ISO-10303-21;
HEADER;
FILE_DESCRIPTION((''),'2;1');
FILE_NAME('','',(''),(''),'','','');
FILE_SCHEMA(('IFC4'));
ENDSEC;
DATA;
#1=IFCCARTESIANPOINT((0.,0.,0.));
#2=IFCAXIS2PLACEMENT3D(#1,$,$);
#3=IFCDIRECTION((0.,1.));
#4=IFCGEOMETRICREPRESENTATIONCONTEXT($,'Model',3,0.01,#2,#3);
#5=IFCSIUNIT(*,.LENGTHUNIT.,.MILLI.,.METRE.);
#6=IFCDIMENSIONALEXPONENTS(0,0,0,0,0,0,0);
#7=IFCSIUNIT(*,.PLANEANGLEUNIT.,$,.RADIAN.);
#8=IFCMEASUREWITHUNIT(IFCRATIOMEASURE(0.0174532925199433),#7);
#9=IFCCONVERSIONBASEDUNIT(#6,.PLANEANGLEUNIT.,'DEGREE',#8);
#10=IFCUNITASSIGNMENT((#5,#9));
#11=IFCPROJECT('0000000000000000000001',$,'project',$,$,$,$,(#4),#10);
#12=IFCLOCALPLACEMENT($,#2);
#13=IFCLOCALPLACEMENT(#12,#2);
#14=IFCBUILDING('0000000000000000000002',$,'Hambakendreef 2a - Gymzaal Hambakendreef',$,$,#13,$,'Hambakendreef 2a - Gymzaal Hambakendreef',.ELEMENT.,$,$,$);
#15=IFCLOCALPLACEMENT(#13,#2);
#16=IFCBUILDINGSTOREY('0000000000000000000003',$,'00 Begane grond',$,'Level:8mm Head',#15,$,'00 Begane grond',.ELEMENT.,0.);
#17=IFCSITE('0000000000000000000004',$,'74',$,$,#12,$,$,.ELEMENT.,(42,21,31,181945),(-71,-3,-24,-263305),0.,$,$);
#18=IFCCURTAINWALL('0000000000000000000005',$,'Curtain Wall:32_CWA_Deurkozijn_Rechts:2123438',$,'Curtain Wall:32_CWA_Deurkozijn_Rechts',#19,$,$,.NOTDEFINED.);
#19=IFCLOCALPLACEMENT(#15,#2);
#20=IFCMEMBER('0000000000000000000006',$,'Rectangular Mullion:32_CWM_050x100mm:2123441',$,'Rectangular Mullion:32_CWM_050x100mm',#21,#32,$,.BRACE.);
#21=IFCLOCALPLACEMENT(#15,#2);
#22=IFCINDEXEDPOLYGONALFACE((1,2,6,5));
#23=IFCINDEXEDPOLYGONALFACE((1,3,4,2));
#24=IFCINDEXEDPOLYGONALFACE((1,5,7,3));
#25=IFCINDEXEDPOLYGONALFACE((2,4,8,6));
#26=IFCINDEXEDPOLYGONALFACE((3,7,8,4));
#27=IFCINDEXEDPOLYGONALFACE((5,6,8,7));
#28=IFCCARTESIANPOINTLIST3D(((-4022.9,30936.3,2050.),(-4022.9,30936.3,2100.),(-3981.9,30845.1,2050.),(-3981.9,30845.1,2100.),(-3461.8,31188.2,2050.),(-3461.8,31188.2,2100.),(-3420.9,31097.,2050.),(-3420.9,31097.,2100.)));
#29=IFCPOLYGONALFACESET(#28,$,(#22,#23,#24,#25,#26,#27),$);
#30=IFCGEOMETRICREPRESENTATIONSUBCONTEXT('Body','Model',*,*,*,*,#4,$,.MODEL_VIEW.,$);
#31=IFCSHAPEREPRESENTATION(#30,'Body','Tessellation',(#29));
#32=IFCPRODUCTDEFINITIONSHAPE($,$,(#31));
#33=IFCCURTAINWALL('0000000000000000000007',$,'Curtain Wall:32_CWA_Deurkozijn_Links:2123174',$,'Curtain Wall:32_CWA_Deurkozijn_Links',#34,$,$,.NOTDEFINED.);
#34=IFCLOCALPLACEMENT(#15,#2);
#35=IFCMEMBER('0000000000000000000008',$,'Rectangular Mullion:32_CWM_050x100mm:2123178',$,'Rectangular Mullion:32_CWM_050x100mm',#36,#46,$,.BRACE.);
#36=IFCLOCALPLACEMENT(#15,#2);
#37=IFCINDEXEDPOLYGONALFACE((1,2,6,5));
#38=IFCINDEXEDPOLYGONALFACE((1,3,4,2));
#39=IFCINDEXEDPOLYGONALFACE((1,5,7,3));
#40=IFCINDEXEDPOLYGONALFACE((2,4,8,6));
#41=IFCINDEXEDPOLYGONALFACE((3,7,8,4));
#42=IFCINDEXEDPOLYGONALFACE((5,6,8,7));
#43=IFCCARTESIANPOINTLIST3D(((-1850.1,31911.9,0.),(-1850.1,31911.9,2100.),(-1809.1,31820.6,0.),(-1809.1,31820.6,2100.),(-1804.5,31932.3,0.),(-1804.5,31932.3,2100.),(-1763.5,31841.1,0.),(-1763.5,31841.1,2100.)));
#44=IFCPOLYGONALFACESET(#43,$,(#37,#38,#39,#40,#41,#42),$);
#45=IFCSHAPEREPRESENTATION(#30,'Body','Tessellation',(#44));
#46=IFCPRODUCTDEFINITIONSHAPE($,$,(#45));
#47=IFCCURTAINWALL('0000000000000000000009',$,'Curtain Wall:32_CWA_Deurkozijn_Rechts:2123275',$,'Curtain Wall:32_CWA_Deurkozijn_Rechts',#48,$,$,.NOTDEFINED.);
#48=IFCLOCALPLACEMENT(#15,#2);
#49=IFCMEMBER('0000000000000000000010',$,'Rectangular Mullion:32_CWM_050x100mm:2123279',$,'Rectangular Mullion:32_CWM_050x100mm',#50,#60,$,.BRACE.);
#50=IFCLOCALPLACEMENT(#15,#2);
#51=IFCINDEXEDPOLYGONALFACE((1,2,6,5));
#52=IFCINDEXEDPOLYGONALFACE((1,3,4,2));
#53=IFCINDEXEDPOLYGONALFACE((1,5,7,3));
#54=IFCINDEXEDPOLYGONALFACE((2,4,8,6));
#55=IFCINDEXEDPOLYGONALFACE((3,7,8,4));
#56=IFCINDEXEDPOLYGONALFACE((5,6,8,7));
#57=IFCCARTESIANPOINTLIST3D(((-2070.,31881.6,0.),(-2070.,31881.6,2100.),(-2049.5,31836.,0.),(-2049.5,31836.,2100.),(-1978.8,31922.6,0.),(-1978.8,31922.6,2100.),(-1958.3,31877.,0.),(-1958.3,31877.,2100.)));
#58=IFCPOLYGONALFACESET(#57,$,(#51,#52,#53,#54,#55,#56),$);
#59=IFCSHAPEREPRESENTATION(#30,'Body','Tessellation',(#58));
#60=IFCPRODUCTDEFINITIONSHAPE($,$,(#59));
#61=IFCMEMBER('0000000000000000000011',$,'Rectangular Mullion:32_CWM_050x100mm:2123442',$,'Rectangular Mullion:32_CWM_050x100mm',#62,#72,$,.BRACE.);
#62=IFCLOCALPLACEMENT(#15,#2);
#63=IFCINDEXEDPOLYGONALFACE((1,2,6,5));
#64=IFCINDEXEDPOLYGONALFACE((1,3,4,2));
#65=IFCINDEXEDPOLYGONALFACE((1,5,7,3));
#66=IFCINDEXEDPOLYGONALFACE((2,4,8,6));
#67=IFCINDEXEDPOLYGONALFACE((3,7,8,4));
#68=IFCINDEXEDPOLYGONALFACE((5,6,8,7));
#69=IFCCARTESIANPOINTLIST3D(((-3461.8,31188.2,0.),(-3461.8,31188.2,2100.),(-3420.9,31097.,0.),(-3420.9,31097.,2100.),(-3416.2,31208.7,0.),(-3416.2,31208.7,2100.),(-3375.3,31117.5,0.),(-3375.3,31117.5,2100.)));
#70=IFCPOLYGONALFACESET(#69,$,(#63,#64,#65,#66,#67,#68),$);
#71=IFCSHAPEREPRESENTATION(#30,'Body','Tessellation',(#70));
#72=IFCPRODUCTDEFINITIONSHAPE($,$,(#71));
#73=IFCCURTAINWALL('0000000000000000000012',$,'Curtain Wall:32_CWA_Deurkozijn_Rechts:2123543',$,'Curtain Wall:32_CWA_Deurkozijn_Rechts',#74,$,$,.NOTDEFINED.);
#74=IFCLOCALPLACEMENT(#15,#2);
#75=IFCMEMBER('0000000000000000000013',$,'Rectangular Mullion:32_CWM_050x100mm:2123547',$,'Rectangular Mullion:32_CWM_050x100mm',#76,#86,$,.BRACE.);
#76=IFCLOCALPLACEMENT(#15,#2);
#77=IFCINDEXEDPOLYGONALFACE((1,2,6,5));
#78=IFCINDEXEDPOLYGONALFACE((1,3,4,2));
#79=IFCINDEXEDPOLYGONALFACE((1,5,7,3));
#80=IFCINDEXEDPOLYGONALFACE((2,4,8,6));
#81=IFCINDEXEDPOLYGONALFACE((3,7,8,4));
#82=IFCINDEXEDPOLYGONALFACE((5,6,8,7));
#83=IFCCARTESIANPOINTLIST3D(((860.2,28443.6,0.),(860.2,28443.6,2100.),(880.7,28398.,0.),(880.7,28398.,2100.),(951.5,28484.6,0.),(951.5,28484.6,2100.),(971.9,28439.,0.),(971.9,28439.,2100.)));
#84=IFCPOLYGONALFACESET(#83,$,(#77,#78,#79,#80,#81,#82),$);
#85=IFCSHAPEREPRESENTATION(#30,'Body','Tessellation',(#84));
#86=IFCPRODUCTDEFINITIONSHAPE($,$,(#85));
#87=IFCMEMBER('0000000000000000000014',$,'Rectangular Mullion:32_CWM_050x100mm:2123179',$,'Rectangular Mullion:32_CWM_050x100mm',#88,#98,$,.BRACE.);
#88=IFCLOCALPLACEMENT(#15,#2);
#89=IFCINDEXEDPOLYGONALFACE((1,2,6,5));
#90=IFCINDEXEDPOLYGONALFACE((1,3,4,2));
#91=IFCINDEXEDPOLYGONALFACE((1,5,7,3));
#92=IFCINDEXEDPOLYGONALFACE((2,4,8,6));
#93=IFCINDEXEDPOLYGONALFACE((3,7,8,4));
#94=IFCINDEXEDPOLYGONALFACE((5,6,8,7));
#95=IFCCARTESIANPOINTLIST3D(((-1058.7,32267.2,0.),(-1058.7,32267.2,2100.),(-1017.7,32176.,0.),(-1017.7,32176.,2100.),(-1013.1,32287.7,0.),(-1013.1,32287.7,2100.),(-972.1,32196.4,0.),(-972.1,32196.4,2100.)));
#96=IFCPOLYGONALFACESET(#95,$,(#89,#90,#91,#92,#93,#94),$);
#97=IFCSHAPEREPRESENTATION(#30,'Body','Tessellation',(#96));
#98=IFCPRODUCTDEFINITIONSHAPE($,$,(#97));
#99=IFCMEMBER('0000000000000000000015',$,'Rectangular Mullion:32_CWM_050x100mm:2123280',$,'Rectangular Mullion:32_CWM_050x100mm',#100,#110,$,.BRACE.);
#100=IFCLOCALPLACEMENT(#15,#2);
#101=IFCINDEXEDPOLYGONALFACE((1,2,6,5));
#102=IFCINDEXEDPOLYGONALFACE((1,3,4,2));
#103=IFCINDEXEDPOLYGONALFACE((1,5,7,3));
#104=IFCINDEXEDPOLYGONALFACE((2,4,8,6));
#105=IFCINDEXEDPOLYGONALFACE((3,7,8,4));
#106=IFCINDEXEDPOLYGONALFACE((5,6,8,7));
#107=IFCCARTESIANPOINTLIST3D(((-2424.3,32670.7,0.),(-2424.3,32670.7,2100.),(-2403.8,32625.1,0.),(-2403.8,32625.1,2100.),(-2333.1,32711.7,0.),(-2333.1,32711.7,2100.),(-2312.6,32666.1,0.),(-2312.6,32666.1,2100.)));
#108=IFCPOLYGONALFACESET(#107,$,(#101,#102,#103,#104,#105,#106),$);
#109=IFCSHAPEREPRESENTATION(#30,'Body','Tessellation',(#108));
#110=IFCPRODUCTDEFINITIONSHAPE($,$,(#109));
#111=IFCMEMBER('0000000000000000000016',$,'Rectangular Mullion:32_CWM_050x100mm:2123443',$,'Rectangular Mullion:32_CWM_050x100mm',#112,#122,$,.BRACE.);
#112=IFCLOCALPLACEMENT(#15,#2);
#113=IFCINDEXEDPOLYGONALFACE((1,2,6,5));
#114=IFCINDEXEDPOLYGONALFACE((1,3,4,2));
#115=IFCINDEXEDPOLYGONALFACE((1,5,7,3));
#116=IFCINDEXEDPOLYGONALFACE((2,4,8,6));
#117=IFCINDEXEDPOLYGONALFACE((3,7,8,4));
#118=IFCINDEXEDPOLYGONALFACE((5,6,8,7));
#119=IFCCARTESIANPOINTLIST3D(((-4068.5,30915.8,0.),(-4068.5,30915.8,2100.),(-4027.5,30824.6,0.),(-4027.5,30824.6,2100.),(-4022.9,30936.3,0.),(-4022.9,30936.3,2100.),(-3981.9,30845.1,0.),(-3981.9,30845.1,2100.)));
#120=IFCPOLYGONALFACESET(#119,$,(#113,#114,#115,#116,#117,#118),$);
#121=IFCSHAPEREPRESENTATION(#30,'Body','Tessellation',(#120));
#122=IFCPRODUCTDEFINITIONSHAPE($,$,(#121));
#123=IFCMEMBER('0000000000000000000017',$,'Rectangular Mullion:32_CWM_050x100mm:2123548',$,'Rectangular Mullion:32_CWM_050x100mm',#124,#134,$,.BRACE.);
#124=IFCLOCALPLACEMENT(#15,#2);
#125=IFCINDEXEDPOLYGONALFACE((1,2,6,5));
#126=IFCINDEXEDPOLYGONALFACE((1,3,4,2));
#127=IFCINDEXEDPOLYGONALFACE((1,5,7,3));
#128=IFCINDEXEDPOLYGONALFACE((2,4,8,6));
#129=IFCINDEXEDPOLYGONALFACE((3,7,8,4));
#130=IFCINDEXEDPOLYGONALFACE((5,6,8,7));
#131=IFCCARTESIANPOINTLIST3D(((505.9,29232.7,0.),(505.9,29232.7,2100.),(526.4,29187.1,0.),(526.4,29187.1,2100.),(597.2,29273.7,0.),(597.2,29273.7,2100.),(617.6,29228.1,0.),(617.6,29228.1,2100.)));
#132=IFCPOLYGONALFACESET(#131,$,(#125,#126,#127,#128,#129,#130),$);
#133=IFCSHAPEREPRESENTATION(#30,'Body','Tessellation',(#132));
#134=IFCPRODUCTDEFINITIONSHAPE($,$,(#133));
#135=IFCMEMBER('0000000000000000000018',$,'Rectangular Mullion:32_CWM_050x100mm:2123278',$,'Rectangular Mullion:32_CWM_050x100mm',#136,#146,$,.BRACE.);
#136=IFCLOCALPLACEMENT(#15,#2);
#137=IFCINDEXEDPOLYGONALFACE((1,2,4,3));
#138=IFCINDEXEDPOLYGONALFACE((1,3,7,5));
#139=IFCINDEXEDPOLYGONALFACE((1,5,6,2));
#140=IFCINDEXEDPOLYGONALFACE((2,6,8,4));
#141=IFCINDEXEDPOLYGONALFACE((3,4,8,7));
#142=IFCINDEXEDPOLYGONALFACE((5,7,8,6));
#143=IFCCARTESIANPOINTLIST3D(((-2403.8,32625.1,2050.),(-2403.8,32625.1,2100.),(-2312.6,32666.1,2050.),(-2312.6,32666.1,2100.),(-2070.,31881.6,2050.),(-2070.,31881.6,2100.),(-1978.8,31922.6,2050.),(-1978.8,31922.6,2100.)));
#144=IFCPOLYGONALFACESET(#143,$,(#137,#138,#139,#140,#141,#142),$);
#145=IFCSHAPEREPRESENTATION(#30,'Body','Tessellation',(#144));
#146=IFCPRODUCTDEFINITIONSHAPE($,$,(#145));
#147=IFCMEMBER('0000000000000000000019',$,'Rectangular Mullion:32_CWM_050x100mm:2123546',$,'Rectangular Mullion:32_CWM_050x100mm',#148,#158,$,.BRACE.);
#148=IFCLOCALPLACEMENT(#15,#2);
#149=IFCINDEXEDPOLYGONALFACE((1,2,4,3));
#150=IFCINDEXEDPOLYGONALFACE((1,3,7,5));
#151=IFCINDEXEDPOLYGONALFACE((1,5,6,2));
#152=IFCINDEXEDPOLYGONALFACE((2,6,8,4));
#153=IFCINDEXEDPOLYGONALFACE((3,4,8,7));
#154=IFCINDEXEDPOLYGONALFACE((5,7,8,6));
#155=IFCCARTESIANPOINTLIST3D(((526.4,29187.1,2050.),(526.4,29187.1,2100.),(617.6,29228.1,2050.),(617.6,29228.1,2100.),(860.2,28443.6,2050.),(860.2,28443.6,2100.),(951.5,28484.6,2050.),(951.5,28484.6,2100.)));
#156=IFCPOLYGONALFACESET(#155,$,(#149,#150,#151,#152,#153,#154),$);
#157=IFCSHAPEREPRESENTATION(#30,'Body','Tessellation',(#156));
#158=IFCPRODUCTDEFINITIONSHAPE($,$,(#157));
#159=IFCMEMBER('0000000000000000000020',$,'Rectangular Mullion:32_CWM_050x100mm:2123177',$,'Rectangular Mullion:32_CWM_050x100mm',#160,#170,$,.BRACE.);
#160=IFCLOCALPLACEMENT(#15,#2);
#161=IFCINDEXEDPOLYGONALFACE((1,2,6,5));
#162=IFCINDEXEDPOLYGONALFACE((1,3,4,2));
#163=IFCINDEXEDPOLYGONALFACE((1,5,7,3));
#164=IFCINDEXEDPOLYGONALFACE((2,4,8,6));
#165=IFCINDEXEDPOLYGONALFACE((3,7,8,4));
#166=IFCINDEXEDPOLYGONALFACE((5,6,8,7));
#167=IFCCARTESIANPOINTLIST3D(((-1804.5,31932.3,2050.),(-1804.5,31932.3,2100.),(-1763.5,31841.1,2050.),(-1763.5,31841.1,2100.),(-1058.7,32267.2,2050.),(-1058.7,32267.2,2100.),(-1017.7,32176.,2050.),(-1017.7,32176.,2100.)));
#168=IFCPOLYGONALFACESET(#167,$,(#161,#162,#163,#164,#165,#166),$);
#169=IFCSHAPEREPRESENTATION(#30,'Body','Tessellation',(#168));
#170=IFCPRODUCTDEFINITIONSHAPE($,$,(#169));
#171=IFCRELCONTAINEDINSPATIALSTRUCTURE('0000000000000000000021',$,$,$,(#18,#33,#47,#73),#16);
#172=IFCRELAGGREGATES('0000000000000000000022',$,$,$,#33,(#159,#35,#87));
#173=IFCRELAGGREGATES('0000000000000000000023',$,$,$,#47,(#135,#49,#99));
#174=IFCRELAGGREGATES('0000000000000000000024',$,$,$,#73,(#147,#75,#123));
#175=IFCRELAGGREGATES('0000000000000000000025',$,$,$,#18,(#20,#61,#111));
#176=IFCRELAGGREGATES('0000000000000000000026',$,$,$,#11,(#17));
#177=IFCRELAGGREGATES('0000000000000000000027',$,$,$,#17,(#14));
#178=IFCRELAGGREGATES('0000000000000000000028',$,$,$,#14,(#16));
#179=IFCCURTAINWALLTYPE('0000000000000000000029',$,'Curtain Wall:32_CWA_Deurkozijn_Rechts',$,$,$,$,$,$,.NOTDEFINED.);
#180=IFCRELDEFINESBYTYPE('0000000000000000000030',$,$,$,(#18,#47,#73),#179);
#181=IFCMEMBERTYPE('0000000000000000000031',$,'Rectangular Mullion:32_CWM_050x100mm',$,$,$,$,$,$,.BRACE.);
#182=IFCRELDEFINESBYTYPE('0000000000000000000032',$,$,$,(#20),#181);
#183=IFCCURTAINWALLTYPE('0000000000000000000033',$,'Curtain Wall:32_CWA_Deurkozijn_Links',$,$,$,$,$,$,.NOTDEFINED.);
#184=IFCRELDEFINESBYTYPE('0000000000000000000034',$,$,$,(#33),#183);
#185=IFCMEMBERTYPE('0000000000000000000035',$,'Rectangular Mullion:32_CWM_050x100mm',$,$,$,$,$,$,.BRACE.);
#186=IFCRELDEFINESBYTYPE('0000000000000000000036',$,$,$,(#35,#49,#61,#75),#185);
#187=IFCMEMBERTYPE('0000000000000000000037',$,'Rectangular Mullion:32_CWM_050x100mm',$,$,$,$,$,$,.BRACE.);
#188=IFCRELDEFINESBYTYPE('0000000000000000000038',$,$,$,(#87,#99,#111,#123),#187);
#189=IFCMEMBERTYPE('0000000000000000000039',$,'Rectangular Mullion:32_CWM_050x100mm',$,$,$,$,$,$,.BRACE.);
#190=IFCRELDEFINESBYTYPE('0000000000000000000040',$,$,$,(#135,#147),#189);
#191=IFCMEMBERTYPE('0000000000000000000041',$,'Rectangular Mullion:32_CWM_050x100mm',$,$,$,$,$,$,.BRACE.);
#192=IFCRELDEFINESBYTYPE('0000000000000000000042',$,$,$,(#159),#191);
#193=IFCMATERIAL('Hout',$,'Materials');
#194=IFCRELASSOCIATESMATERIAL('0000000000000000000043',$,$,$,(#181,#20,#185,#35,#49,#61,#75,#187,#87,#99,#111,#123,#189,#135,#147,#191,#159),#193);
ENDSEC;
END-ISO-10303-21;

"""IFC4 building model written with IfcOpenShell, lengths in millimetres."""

from ifc_helpers import new_model, entity, si_unit, converted_unit, direction, frame, origin, place, context, subcontext, project, spatial, indexed_curve, outline, extrude, source, transform, mapped, material, type_object, type_shapes, element, aggregate, save


model = new_model("IFC4")

# Units and contexts
model_context = context("Model", 3, precision=0.01, world=origin(), true_north=direction((0.0, 1.0)))
body_context = subcontext(model_context, "Body", "Model", "MODEL_VIEW")
ifc_project = project(units=[si_unit("LENGTHUNIT", "METRE", prefix="MILLI"), converted_unit("PLANEANGLEUNIT", "DEGREE", entity("IfcRatioMeasure", 0.0174532925199433), si_unit("PLANEANGLEUNIT", "RADIAN"), dimensions=[0, 0, 0, 0, 0, 0, 0])], contexts=[model_context])

# Site, building, storey
site_placement = place(None, origin())
site = spatial("IfcSite", under=ifc_project, at=site_placement, Name="74", CompositionType="ELEMENT", RefLatitude=(42, 21, 31, 181945), RefLongitude=(-71, -3, -24, -263305), RefElevation=0.0)
building_placement = place(site_placement, origin())
building = spatial("IfcBuilding", under=site, at=building_placement, Name="Hambakendreef 2a - Gymzaal Hambakendreef", LongName="Hambakendreef 2a - Gymzaal Hambakendreef", CompositionType="ELEMENT")
storey_placement = place(building_placement, origin())
storey = spatial("IfcBuildingStorey", under=building, at=storey_placement, Name="00 Begane grond", ObjectType="Level:8mm Head", LongName="00 Begane grond", CompositionType="ELEMENT", Elevation=0.0)

# Curtain walls, members
curtain_wall_type_1 = type_object("IfcCurtainWallType", Name="Curtain Wall:32_CWA_Deurkozijn_Rechts", PredefinedType="NOTDEFINED")
curtain_wall_1_placement = place(storey_placement, origin())
curtain_wall_1 = element("IfcCurtainWall", 1, at=curtain_wall_1_placement, inside=storey, type_object=curtain_wall_type_1, Name="Curtain Wall:32_CWA_Deurkozijn_Rechts:2123438", ObjectType="Curtain Wall:32_CWA_Deurkozijn_Rechts", PredefinedType="NOTDEFINED")
ifc_material_1 = material(Name="Hout", Category="Materials")
member_type_1 = type_object("IfcMemberType", Name="Rectangular Mullion:32_CWM_050x100mm", PredefinedType="BRACE", material=ifc_material_1)
shared_shape_1 = source(origin(), body_context, "Body", "SweptSolid", [
    extrude(outline(indexed_curve([(-50.0, -25.0), (50.0, -25.0), (50.0, 25.0), (-50.0, 25.0), (-50.0, -25.0)], self_intersect=False)), frame((-25.0, 0.0, -615.0), z_axis=(0.0, 0.0, 1.0), x_axis=(0.0, -1.0, 0.0)), (0.0, 0.0, 1.0), 615.0),
])
type_shapes(member_type_1, [shared_shape_1])
member_1_placement = place(storey_placement, frame((-3441.4, 31142.6, 2100.0), z_axis=(0.91227, 0.40959, 0.0), x_axis=(0.0, 0.0, 1.0)))
member_1 = element("IfcMember", 2, at=member_1_placement, type_object=member_type_1, material=ifc_material_1, Name="Rectangular Mullion:32_CWM_050x100mm:2123441", ObjectType="Rectangular Mullion:32_CWM_050x100mm", PredefinedType="BRACE", context=body_context, shape_type="MappedRepresentation", body=[
    mapped(shared_shape_1, transform((0.0, 0.0, 0.0), scale=1.0)),
])
curtain_wall_type_2 = type_object("IfcCurtainWallType", Name="Curtain Wall:32_CWA_Deurkozijn_Links", PredefinedType="NOTDEFINED")
curtain_wall_2_placement = place(storey_placement, origin())
curtain_wall_2 = element("IfcCurtainWall", 3, at=curtain_wall_2_placement, inside=storey, type_object=curtain_wall_type_2, Name="Curtain Wall:32_CWA_Deurkozijn_Links:2123174", ObjectType="Curtain Wall:32_CWA_Deurkozijn_Links", PredefinedType="NOTDEFINED")
member_type_2 = type_object("IfcMemberType", Name="Rectangular Mullion:32_CWM_050x100mm", PredefinedType="BRACE", material=ifc_material_1)
shared_shape_2 = source(origin(), body_context, "Body", "SweptSolid", [
    extrude(outline(indexed_curve([(-50.0, -25.0), (50.0, -25.0), (50.0, 25.0), (-50.0, 25.0), (-50.0, -25.0)], self_intersect=False)), frame((-25.0, 0.0, -2100.0), z_axis=(0.0, 0.0, 1.0), x_axis=(0.0, -1.0, 0.0)), (0.0, 0.0, 1.0), 2100.0),
])
type_shapes(member_type_2, [shared_shape_2])
member_2_placement = place(storey_placement, frame((-1829.6, 31866.2, 0.0), z_axis=(0.0, 0.0, -1.0), x_axis=(-0.91227, -0.40959, 0.0)))
member_2 = element("IfcMember", 4, at=member_2_placement, type_object=member_type_2, material=ifc_material_1, Name="Rectangular Mullion:32_CWM_050x100mm:2123178", ObjectType="Rectangular Mullion:32_CWM_050x100mm", PredefinedType="BRACE", context=body_context, shape_type="MappedRepresentation", body=[
    mapped(shared_shape_2, transform((0.0, 0.0, 0.0), scale=1.0)),
])
curtain_wall_3_placement = place(storey_placement, origin())
curtain_wall_3 = element("IfcCurtainWall", 5, at=curtain_wall_3_placement, inside=storey, type_object=curtain_wall_type_1, Name="Curtain Wall:32_CWA_Deurkozijn_Rechts:2123275", ObjectType="Curtain Wall:32_CWA_Deurkozijn_Rechts", PredefinedType="NOTDEFINED")
member_3_placement = place(storey_placement, frame((-2003.9, 31856.5, 0.0), z_axis=(0.0, 0.0, -1.0), x_axis=(0.40959, -0.91227, 0.0)))
member_3 = element("IfcMember", 6, at=member_3_placement, type_object=member_type_2, material=ifc_material_1, Name="Rectangular Mullion:32_CWM_050x100mm:2123279", ObjectType="Rectangular Mullion:32_CWM_050x100mm", PredefinedType="BRACE", context=body_context, shape_type="MappedRepresentation", body=[
    mapped(shared_shape_2, transform((0.0, 0.0, 0.0), scale=1.0)),
])

# Member
member_4_placement = place(storey_placement, frame((-3395.8, 31163.1, 0.0), z_axis=(0.0, 0.0, -1.0), x_axis=(0.91227, 0.40959, 0.0)))
member_4 = element("IfcMember", 7, at=member_4_placement, type_object=member_type_2, material=ifc_material_1, Name="Rectangular Mullion:32_CWM_050x100mm:2123442", ObjectType="Rectangular Mullion:32_CWM_050x100mm", PredefinedType="BRACE", context=body_context, shape_type="MappedRepresentation", body=[
    mapped(shared_shape_2, transform((0.0, 0.0, 0.0), scale=1.0)),
])

# Curtain wall, member
curtain_wall_4_placement = place(storey_placement, origin())
curtain_wall_4 = element("IfcCurtainWall", 8, at=curtain_wall_4_placement, inside=storey, type_object=curtain_wall_type_1, Name="Curtain Wall:32_CWA_Deurkozijn_Rechts:2123543", ObjectType="Curtain Wall:32_CWA_Deurkozijn_Rechts", PredefinedType="NOTDEFINED")
member_5_placement = place(storey_placement, frame((926.3, 28418.5, 0.0), z_axis=(0.0, 0.0, -1.0), x_axis=(0.40959, -0.91227, 0.0)))
member_5 = element("IfcMember", 9, at=member_5_placement, type_object=member_type_2, material=ifc_material_1, Name="Rectangular Mullion:32_CWM_050x100mm:2123547", ObjectType="Rectangular Mullion:32_CWM_050x100mm", PredefinedType="BRACE", context=body_context, shape_type="MappedRepresentation", body=[
    mapped(shared_shape_2, transform((0.0, 0.0, 0.0), scale=1.0)),
])

# Members
member_type_3 = type_object("IfcMemberType", Name="Rectangular Mullion:32_CWM_050x100mm", PredefinedType="BRACE", material=ifc_material_1)
shared_shape_3 = source(origin(), body_context, "Body", "SweptSolid", [
    extrude(outline(indexed_curve([(-50.0, -25.0), (50.0, -25.0), (50.0, 25.0), (-50.0, 25.0), (-50.0, -25.0)], self_intersect=False)), frame((-25.0, 0.0, -2100.0), z_axis=(0.0, 0.0, 1.0), x_axis=(0.0, -1.0, 0.0)), (0.0, 0.0, 1.0), 2100.0),
])
type_shapes(member_type_3, [shared_shape_3])
member_6_placement = place(storey_placement, frame((-992.6, 32242.0, 2100.0), z_axis=(0.0, 0.0, 1.0), x_axis=(0.91227, 0.40959, 0.0)))
member_6 = element("IfcMember", 10, at=member_6_placement, type_object=member_type_3, material=ifc_material_1, Name="Rectangular Mullion:32_CWM_050x100mm:2123179", ObjectType="Rectangular Mullion:32_CWM_050x100mm", PredefinedType="BRACE", context=body_context, shape_type="MappedRepresentation", body=[
    mapped(shared_shape_3, transform((0.0, 0.0, 0.0), scale=1.0)),
])
member_7_placement = place(storey_placement, frame((-2378.7, 32691.2, 2100.0), z_axis=(0.0, 0.0, 1.0), x_axis=(-0.40959, 0.91227, 0.0)))
member_7 = element("IfcMember", 11, at=member_7_placement, type_object=member_type_3, material=ifc_material_1, Name="Rectangular Mullion:32_CWM_050x100mm:2123280", ObjectType="Rectangular Mullion:32_CWM_050x100mm", PredefinedType="BRACE", context=body_context, shape_type="MappedRepresentation", body=[
    mapped(shared_shape_3, transform((0.0, 0.0, 0.0), scale=1.0)),
])
member_8_placement = place(storey_placement, frame((-4048.0, 30870.2, 2100.0), z_axis=(0.0, 0.0, 1.0), x_axis=(-0.91227, -0.40959, 0.0)))
member_8 = element("IfcMember", 12, at=member_8_placement, type_object=member_type_3, material=ifc_material_1, Name="Rectangular Mullion:32_CWM_050x100mm:2123443", ObjectType="Rectangular Mullion:32_CWM_050x100mm", PredefinedType="BRACE", context=body_context, shape_type="MappedRepresentation", body=[
    mapped(shared_shape_3, transform((0.0, 0.0, 0.0), scale=1.0)),
])
member_9_placement = place(storey_placement, frame((551.5, 29253.2, 2100.0), z_axis=(0.0, 0.0, 1.0), x_axis=(-0.40959, 0.91227, 0.0)))
member_9 = element("IfcMember", 13, at=member_9_placement, type_object=member_type_3, material=ifc_material_1, Name="Rectangular Mullion:32_CWM_050x100mm:2123548", ObjectType="Rectangular Mullion:32_CWM_050x100mm", PredefinedType="BRACE", context=body_context, shape_type="MappedRepresentation", body=[
    mapped(shared_shape_3, transform((0.0, 0.0, 0.0), scale=1.0)),
])
member_type_4 = type_object("IfcMemberType", Name="Rectangular Mullion:32_CWM_050x100mm", PredefinedType="BRACE", material=ifc_material_1)
shared_shape_4 = source(origin(), body_context, "Body", "SweptSolid", [
    extrude(outline(indexed_curve([(-50.0, -25.0), (50.0, -25.0), (50.0, 25.0), (-50.0, 25.0), (-50.0, -25.0)], self_intersect=False)), frame((-25.0, 0.0, -815.0), z_axis=(0.0, 0.0, 1.0), x_axis=(0.0, -1.0, 0.0)), (0.0, 0.0, 1.0), 815.0),
])
type_shapes(member_type_4, [shared_shape_4])
member_10_placement = place(storey_placement, frame((-2024.4, 31902.1, 2100.0), z_axis=(0.40959, -0.91227, 0.0), x_axis=(0.0, 0.0, 1.0)))
member_10 = element("IfcMember", 14, at=member_10_placement, type_object=member_type_4, material=ifc_material_1, Name="Rectangular Mullion:32_CWM_050x100mm:2123278", ObjectType="Rectangular Mullion:32_CWM_050x100mm", PredefinedType="BRACE", context=body_context, shape_type="MappedRepresentation", body=[
    mapped(shared_shape_4, transform((0.0, 0.0, 0.0), scale=1.0)),
])
member_11_placement = place(storey_placement, frame((905.8, 28464.1, 2100.0), z_axis=(0.40959, -0.91227, 0.0), x_axis=(0.0, 0.0, 1.0)))
member_11 = element("IfcMember", 15, at=member_11_placement, type_object=member_type_4, material=ifc_material_1, Name="Rectangular Mullion:32_CWM_050x100mm:2123546", ObjectType="Rectangular Mullion:32_CWM_050x100mm", PredefinedType="BRACE", context=body_context, shape_type="MappedRepresentation", body=[
    mapped(shared_shape_4, transform((0.0, 0.0, 0.0), scale=1.0)),
])
member_type_5 = type_object("IfcMemberType", Name="Rectangular Mullion:32_CWM_050x100mm", PredefinedType="BRACE", material=ifc_material_1)
shared_shape_5 = source(origin(), body_context, "Body", "SweptSolid", [
    extrude(outline(indexed_curve([(-50.0, -25.0), (50.0, -25.0), (50.0, 25.0), (-50.0, 25.0), (-50.0, -25.0)], self_intersect=False)), frame((-25.0, 0.0, -817.5), z_axis=(0.0, 0.0, 1.0), x_axis=(0.0, -1.0, 0.0)), (0.0, 0.0, 1.0), 817.5),
])
type_shapes(member_type_5, [shared_shape_5])
member_12_placement = place(storey_placement, frame((-1784.0, 31886.7, 2100.0), z_axis=(-0.91227, -0.40959, 0.0), x_axis=(0.0, 0.0, 1.0)))
member_12 = element("IfcMember", 16, at=member_12_placement, type_object=member_type_5, material=ifc_material_1, Name="Rectangular Mullion:32_CWM_050x100mm:2123177", ObjectType="Rectangular Mullion:32_CWM_050x100mm", PredefinedType="BRACE", context=body_context, shape_type="MappedRepresentation", body=[
    mapped(shared_shape_5, transform((0.0, 0.0, 0.0), scale=1.0)),
])

aggregate(curtain_wall_2, [member_12, member_2, member_6])
aggregate(curtain_wall_3, [member_10, member_3, member_7])
aggregate(curtain_wall_4, [member_11, member_5, member_9])
aggregate(curtain_wall_1, [member_1, member_4, member_8])

save(model, "model.ifc")
